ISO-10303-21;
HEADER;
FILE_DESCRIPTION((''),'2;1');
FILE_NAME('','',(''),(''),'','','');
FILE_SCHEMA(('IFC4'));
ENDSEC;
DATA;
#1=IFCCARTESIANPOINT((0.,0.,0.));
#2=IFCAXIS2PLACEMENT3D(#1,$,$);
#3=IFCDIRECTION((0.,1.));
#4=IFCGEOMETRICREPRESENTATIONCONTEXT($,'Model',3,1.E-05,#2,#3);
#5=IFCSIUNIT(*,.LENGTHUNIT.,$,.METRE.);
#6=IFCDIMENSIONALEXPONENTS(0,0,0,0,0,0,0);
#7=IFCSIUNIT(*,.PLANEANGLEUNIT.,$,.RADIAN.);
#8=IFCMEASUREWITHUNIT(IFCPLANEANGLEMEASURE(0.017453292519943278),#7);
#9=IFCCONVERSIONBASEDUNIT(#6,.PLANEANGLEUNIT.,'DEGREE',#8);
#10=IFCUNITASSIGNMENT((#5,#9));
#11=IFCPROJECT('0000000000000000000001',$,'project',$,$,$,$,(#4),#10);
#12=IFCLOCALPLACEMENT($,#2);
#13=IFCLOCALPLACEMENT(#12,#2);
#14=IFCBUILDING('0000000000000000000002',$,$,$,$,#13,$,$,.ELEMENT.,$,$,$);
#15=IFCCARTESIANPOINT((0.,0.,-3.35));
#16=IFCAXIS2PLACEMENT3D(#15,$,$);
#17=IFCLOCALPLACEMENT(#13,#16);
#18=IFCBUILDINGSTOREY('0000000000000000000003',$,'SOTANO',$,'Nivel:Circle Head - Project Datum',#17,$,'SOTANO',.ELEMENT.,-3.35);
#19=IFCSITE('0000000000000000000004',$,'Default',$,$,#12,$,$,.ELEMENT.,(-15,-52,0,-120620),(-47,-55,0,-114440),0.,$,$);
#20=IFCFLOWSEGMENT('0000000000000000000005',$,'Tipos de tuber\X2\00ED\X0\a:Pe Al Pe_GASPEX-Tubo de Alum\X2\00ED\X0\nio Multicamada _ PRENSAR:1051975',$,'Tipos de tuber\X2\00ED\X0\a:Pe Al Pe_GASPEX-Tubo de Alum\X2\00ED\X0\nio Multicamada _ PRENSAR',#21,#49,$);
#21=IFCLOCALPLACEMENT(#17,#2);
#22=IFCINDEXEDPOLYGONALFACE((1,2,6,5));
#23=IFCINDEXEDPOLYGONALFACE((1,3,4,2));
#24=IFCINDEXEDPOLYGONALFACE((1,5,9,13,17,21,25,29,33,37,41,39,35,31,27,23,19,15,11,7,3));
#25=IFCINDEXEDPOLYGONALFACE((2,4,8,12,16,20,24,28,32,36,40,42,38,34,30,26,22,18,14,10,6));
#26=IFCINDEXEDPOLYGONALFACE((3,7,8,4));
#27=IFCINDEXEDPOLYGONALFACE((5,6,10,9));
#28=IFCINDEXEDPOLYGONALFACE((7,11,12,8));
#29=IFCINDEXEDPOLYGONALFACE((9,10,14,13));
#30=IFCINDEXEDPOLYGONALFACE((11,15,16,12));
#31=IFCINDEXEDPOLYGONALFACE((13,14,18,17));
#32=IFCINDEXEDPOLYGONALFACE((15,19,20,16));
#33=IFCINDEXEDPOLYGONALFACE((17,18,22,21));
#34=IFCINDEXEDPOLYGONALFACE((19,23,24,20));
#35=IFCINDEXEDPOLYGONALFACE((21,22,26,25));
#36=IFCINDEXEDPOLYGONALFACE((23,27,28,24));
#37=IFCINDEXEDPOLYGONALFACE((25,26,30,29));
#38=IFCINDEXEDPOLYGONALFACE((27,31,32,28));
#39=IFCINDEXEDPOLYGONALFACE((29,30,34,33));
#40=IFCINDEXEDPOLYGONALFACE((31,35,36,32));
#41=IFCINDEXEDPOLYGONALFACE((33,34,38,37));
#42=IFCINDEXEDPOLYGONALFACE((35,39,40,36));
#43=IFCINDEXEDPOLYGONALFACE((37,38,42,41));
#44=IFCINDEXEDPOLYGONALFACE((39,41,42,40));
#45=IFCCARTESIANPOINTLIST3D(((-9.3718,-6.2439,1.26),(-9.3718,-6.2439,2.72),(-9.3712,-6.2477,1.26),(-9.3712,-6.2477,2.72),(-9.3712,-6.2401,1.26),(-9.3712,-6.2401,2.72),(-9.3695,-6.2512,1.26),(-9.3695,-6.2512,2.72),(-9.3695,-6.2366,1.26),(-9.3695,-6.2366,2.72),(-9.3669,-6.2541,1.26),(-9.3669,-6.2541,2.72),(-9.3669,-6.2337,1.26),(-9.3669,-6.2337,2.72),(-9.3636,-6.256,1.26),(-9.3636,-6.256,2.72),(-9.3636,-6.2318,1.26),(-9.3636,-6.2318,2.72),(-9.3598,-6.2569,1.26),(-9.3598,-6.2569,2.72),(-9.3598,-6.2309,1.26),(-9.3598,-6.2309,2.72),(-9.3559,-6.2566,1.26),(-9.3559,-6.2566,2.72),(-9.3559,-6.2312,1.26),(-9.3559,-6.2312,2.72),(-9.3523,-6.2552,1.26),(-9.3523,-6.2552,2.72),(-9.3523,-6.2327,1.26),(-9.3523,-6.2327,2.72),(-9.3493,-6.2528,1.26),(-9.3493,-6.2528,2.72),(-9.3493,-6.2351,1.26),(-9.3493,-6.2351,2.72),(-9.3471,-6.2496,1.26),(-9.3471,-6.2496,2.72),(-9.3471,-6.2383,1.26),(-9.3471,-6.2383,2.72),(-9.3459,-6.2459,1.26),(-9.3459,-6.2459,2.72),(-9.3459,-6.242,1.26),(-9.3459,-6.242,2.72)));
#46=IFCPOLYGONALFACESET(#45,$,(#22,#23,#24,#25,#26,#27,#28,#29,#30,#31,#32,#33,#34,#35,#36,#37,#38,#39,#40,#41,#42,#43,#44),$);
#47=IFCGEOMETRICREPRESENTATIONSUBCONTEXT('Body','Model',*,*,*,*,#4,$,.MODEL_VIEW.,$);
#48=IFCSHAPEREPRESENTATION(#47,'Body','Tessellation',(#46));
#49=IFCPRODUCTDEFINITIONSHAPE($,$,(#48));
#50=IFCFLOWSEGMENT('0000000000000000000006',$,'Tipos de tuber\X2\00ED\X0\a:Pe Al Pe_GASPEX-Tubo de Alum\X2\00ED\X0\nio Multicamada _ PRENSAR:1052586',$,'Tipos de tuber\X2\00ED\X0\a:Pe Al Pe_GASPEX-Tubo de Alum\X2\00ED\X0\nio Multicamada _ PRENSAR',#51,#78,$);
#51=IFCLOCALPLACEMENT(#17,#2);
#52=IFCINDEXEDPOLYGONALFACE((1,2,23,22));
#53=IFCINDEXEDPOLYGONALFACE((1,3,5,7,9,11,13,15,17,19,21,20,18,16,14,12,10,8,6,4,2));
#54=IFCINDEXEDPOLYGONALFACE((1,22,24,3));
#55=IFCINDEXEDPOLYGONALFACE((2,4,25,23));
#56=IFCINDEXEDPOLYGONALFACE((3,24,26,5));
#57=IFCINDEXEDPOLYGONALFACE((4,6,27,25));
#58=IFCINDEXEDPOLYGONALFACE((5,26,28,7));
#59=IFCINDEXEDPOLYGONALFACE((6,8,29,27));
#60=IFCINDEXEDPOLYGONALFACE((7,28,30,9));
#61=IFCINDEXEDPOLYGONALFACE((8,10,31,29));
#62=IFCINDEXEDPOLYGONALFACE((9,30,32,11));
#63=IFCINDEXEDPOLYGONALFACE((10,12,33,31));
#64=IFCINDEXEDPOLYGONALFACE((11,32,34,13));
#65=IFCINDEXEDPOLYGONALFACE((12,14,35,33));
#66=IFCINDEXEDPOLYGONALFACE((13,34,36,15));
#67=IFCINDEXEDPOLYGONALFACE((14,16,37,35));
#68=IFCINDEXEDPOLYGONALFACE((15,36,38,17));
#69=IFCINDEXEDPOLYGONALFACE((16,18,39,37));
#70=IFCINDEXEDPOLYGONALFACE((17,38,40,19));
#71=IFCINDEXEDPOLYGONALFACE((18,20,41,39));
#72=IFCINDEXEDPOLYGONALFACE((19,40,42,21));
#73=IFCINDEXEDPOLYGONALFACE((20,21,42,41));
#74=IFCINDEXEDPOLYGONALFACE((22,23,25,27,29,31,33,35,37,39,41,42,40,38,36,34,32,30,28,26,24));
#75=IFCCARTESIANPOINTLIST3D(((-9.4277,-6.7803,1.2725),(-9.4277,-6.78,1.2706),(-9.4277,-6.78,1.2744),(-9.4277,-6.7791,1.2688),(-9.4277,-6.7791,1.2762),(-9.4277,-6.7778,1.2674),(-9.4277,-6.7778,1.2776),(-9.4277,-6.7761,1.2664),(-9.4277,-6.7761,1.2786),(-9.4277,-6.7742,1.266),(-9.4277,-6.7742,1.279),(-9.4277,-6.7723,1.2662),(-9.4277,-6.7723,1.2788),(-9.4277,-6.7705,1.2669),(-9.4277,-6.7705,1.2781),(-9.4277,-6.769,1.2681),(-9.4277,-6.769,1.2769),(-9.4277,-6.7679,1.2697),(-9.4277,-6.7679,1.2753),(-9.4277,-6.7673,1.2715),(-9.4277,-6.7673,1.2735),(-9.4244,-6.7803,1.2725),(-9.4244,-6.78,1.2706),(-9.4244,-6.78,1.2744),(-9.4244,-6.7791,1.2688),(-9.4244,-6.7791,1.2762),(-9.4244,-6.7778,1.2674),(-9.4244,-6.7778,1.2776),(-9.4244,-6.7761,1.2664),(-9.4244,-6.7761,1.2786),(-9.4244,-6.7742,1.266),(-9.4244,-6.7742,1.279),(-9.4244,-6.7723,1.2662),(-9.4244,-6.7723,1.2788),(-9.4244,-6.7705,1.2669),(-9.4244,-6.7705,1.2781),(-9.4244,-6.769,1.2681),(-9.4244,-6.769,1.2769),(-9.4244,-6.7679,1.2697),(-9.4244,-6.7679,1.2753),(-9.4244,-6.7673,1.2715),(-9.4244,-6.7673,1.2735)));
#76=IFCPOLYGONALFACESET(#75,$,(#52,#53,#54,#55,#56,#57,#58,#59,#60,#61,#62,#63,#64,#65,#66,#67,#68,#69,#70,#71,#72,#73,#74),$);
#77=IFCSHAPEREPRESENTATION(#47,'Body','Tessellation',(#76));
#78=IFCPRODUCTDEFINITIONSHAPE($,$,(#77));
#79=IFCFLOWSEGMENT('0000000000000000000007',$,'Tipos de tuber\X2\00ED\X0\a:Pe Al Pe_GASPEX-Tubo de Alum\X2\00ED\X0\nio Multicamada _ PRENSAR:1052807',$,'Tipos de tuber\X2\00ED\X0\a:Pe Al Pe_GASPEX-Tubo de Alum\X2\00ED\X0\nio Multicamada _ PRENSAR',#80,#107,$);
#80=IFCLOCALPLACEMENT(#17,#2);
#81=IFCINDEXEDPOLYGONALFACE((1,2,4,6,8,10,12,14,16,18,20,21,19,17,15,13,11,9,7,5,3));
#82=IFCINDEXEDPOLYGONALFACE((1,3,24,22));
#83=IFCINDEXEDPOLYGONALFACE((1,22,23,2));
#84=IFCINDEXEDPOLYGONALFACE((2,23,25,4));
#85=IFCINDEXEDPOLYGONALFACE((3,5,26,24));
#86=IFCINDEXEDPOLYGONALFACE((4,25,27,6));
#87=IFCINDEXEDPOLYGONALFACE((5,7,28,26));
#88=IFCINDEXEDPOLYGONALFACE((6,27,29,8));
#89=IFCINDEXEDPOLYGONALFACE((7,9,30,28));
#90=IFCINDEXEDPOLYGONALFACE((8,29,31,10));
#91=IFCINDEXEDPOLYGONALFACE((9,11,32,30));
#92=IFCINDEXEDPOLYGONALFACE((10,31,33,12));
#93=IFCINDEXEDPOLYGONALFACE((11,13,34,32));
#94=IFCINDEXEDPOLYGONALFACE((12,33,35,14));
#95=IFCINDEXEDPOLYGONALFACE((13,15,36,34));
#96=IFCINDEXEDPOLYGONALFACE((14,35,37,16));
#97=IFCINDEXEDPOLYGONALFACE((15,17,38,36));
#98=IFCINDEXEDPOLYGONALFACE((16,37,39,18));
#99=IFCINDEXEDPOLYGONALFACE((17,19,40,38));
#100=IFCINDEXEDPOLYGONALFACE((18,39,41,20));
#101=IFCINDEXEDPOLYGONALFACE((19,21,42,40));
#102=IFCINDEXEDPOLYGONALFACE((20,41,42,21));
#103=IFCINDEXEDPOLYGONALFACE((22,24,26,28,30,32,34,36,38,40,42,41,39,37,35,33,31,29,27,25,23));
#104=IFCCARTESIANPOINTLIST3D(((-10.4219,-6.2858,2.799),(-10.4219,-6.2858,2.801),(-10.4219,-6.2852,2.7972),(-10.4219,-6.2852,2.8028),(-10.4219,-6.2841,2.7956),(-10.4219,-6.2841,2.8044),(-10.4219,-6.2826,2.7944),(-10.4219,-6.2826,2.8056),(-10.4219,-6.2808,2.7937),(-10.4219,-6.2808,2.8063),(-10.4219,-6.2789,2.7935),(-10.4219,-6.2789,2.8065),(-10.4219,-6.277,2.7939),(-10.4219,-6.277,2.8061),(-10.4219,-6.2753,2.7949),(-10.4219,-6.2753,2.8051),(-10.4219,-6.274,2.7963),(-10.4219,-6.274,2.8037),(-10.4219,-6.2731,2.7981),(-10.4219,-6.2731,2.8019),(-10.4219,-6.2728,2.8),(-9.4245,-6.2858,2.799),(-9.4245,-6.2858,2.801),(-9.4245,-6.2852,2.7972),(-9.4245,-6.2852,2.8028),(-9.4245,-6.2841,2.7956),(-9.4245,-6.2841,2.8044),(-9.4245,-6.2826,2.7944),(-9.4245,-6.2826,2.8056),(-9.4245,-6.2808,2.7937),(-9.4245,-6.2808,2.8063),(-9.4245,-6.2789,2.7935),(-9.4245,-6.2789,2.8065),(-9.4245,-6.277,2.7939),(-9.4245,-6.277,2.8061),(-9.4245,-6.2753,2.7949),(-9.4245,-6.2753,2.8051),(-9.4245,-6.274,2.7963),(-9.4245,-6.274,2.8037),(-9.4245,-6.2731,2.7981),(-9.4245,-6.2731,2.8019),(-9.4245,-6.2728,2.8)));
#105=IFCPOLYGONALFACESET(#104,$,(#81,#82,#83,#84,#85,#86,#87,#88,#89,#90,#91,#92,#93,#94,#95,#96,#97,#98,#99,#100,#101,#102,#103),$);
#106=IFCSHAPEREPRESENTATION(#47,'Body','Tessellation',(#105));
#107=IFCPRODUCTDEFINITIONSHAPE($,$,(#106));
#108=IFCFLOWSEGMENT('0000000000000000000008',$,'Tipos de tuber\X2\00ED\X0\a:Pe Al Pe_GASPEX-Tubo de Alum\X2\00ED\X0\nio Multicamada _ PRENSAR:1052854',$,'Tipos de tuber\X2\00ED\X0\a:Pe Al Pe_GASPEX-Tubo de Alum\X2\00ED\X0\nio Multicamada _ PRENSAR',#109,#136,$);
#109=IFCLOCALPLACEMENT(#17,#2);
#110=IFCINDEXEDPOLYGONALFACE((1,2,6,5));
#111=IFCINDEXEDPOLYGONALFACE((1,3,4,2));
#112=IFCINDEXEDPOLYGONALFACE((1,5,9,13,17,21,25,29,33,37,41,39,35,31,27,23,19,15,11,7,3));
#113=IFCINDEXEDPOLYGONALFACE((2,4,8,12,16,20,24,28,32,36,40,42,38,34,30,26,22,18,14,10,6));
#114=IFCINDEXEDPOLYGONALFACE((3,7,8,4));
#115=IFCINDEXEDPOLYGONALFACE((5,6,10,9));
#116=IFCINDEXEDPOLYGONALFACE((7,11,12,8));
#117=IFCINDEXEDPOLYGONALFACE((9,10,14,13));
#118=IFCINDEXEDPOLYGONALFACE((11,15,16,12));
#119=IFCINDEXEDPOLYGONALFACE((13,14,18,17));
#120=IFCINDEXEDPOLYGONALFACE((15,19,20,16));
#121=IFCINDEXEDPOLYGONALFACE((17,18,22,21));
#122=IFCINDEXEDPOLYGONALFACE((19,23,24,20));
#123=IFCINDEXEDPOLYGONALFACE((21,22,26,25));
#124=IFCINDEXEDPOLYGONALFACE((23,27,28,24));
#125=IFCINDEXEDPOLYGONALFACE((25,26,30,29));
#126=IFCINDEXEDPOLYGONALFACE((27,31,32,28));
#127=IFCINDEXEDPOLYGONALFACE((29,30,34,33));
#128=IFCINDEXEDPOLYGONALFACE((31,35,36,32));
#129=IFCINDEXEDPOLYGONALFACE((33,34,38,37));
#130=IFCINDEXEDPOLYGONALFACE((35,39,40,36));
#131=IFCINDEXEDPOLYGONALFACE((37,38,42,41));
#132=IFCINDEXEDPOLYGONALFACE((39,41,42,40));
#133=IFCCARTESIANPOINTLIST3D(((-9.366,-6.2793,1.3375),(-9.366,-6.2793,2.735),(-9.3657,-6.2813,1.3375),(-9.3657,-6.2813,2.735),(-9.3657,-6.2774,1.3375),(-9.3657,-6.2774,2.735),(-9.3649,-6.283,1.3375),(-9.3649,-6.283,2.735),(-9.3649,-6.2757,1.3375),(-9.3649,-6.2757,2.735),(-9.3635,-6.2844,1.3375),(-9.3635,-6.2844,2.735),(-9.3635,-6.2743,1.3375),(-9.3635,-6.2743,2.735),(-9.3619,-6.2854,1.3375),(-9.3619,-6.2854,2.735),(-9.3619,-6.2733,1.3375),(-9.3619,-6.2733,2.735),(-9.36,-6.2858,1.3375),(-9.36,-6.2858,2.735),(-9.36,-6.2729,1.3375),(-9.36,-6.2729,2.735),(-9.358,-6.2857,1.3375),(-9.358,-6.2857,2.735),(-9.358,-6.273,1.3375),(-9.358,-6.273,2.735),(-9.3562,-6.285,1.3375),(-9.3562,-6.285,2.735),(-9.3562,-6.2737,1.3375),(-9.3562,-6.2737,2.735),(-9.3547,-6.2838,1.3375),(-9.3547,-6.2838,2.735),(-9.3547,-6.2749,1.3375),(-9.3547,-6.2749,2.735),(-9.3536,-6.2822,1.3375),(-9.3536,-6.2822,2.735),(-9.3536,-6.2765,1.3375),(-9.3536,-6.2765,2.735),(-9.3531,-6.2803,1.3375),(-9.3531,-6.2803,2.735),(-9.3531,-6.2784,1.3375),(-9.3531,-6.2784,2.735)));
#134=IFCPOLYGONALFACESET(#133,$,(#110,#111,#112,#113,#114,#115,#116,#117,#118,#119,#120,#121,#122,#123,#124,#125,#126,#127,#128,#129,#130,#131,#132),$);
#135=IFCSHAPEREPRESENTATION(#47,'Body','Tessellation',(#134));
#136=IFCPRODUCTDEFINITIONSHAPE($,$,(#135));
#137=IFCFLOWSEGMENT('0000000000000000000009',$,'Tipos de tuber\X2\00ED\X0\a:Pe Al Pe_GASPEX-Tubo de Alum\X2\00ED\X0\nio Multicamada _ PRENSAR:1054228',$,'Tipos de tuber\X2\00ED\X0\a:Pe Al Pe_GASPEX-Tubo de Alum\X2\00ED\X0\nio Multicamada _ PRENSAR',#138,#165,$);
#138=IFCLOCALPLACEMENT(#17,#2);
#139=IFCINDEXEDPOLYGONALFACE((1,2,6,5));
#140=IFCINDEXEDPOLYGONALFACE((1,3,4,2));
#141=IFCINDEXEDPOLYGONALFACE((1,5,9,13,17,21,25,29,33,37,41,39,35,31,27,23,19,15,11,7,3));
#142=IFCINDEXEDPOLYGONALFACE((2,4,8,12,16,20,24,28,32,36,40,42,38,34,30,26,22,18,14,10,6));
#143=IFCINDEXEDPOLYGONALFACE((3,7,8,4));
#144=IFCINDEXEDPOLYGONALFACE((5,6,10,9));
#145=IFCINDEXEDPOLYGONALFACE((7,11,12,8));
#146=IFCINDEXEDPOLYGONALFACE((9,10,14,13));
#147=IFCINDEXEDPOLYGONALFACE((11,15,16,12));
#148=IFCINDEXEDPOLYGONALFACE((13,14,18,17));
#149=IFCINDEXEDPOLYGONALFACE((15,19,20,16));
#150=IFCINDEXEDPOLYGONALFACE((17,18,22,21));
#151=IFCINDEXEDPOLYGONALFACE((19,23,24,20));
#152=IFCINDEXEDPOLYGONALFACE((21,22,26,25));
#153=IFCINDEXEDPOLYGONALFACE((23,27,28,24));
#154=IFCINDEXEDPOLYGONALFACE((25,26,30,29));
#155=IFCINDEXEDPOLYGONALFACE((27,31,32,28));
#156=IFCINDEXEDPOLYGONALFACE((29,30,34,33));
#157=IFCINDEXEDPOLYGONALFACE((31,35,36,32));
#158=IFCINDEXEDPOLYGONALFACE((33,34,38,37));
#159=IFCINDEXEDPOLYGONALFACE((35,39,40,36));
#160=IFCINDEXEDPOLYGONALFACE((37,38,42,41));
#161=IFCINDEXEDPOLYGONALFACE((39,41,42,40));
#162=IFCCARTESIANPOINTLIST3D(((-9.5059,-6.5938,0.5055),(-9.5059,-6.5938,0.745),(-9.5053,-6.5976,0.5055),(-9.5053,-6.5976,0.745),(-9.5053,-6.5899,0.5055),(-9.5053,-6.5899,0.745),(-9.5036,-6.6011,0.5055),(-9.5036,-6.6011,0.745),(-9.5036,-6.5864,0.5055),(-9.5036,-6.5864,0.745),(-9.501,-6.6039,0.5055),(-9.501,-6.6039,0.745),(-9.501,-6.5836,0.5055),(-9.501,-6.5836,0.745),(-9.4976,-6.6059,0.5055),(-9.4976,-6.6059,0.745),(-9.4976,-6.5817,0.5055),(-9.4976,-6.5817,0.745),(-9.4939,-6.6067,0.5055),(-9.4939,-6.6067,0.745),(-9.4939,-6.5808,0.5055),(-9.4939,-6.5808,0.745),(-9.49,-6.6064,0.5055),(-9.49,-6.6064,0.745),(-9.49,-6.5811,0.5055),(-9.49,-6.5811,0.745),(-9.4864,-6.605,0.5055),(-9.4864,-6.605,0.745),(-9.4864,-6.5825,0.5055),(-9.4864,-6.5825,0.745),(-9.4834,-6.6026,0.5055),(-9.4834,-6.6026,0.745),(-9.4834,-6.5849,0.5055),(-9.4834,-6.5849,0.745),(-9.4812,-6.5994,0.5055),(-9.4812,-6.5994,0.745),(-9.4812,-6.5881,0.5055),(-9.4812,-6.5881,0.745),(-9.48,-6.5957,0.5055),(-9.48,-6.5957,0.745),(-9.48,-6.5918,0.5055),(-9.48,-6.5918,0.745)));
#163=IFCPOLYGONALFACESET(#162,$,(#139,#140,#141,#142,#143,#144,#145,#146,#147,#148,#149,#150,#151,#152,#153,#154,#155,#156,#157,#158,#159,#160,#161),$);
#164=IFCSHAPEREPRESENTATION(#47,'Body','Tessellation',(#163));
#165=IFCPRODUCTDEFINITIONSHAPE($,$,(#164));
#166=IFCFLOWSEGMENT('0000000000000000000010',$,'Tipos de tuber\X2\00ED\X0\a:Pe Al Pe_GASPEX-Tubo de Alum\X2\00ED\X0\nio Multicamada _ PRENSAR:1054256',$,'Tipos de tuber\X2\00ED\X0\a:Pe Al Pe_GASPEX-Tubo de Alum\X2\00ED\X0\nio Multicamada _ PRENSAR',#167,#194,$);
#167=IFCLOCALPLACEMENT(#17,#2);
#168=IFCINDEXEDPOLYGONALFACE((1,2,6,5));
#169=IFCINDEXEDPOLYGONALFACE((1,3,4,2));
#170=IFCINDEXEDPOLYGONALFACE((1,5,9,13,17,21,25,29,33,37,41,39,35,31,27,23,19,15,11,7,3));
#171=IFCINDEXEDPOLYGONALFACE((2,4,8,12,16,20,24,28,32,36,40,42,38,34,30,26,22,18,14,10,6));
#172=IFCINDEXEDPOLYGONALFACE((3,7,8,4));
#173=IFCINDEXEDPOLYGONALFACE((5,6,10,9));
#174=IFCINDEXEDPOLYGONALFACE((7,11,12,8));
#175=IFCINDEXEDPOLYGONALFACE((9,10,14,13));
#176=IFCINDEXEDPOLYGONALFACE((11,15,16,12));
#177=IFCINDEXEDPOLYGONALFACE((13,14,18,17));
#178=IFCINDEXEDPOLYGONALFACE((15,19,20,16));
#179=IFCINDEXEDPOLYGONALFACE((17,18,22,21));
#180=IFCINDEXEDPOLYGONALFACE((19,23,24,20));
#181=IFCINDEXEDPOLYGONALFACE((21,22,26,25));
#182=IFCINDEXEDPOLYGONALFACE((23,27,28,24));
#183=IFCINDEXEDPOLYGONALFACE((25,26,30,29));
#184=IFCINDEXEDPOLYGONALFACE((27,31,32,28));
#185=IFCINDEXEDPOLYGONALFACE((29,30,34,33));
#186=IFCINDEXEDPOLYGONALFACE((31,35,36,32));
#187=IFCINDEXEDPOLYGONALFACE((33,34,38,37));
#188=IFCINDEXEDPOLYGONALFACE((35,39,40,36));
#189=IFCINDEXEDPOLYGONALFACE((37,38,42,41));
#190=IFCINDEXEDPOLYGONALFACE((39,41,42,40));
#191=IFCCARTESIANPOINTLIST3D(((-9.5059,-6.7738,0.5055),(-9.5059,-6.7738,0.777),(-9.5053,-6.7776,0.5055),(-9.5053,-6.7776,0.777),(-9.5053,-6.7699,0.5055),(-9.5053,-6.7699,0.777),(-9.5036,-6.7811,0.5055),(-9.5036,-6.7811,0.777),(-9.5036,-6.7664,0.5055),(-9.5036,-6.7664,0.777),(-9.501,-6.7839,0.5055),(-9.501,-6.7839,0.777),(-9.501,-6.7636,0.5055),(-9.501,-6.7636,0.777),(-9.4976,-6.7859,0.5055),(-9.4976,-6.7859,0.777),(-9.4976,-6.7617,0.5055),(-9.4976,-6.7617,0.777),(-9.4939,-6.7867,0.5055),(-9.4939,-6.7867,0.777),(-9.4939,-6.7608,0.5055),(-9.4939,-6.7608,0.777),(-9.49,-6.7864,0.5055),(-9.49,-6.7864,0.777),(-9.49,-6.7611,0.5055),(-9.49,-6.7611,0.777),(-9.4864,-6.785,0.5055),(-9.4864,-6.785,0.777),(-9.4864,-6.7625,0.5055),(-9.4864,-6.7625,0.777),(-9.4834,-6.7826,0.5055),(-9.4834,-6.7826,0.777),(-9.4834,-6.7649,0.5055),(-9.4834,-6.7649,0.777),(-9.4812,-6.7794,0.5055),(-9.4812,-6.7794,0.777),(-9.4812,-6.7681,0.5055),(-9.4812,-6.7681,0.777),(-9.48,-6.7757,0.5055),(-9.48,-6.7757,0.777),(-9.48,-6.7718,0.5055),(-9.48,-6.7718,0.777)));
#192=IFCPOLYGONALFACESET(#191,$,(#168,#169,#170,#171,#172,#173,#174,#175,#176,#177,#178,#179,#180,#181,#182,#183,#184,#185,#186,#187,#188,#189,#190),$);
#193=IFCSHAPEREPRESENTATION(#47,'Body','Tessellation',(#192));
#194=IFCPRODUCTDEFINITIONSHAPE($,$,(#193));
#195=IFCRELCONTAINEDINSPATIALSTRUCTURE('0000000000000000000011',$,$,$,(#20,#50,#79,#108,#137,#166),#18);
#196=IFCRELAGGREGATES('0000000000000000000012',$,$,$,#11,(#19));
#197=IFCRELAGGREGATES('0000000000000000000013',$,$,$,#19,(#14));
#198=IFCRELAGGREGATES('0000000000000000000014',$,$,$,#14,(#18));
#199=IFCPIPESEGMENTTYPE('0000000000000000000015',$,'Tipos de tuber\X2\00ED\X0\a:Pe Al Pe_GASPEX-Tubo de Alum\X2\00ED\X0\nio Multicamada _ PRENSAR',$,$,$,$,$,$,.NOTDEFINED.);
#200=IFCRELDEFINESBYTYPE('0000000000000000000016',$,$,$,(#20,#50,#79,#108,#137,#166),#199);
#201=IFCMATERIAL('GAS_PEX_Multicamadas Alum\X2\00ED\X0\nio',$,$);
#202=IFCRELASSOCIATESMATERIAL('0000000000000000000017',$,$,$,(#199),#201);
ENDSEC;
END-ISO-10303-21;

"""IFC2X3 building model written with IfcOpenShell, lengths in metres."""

from ifc_helpers import new_model, entity, si_unit, converted_unit, direction, frame, frame_2d, origin, origin_2d_with_axis, place, context, subcontext, project, spatial, circle, extrude, material, type_object, element, save


model = new_model("IFC2X3")

# Units and contexts
model_context = context("Model", 3, precision=1e-05, world=origin(), true_north=direction((0.0, 1.0)))
body_context = subcontext(model_context, "Body", "Model", "MODEL_VIEW")
ifc_project = project(units=[si_unit("LENGTHUNIT", "METRE"), converted_unit("PLANEANGLEUNIT", "DEGREE", entity("IfcPlaneAngleMeasure", 0.017453292519943278), si_unit("PLANEANGLEUNIT", "RADIAN"), dimensions=[0, 0, 0, 0, 0, 0, 0])], contexts=[model_context])

# Site, building, storey
site_placement = place(None, origin())
site = spatial("IfcSite", under=ifc_project, at=site_placement, Name="Default", CompositionType="ELEMENT", RefLatitude=(-15, -52, 0, -120620), RefLongitude=(-47, -55, 0, -114440), RefElevation=0.0)
building_placement = place(site_placement, origin())
building = spatial("IfcBuilding", under=site, at=building_placement, CompositionType="ELEMENT")
storey_placement = place(building_placement, frame((0.0, 0.0, -3.35)))
storey = spatial("IfcBuildingStorey", under=building, at=storey_placement, Name="SOTANO", ObjectType="Nivel:Circle Head - Project Datum", LongName="SOTANO", CompositionType="ELEMENT", Elevation=-3.35)

# Flow segments
ifc_material = material(Name="GAS_PEX_Multicamadas Alumínio")
pipe_segment_type_1 = type_object("IfcPipeSegmentType", Name="Tipos de tubería:Pe Al Pe_GASPEX-Tubo de Alumínio Multicamada _ PRENSAR", PredefinedType="NOTDEFINED", material=ifc_material)
flow_segment_1_placement = place(storey_placement, origin())
element("IfcFlowSegment", 1, at=flow_segment_1_placement, inside=storey, type_object=pipe_segment_type_1, Name="Tipos de tubería:Pe Al Pe_GASPEX-Tubo de Alumínio Multicamada _ PRENSAR:1051975", ObjectType="Tipos de tubería:Pe Al Pe_GASPEX-Tubo de Alumínio Multicamada _ PRENSAR", context=body_context, shape_type="SweptSolid", body=[
    extrude(circle(Radius=0.013, at=origin_2d_with_axis()), frame((-9.3588, -6.2439, 1.26), z_axis=(0.0, 0.0, 1.0), x_axis=(-1.0, 0.0, 0.0)), (0.0, 0.0, 1.0), 1.46),
])
flow_segment_2_placement = place(storey_placement, origin())
element("IfcFlowSegment", 2, at=flow_segment_2_placement, inside=storey, type_object=pipe_segment_type_1, Name="Tipos de tubería:Pe Al Pe_GASPEX-Tubo de Alumínio Multicamada _ PRENSAR:1052586", ObjectType="Tipos de tubería:Pe Al Pe_GASPEX-Tubo de Alumínio Multicamada _ PRENSAR", context=body_context, shape_type="SweptSolid", body=[
    extrude(circle(Radius=0.0065, at=origin_2d_with_axis()), frame((-9.4277, -6.7738, 1.2725), z_axis=(1.0, 0.0, 0.0), x_axis=(0.0, -1.0, 0.0)), (0.0, 0.0, 1.0), 0.0033),
])
flow_segment_3_placement = place(storey_placement, origin())
element("IfcFlowSegment", 3, at=flow_segment_3_placement, inside=storey, type_object=pipe_segment_type_1, Name="Tipos de tubería:Pe Al Pe_GASPEX-Tubo de Alumínio Multicamada _ PRENSAR:1052807", ObjectType="Tipos de tubería:Pe Al Pe_GASPEX-Tubo de Alumínio Multicamada _ PRENSAR", context=body_context, shape_type="SweptSolid", body=[
    extrude(circle(Radius=0.0065, at=origin_2d_with_axis()), frame((-10.4219, -6.2793, 2.8), z_axis=(1.0, 0.0, 0.0), x_axis=(0.0, 1.0, 0.0)), (0.0, 0.0, 1.0), 0.9974),
])
flow_segment_4_placement = place(storey_placement, origin())
element("IfcFlowSegment", 4, at=flow_segment_4_placement, inside=storey, type_object=pipe_segment_type_1, Name="Tipos de tubería:Pe Al Pe_GASPEX-Tubo de Alumínio Multicamada _ PRENSAR:1052854", ObjectType="Tipos de tubería:Pe Al Pe_GASPEX-Tubo de Alumínio Multicamada _ PRENSAR", context=body_context, shape_type="SweptSolid", body=[
    extrude(circle(Radius=0.0065, at=origin_2d_with_axis()), frame((-9.3595, -6.2793, 1.3375), z_axis=(0.0, 0.0, 1.0), x_axis=(-1.0, 0.0, 0.0)), (0.0, 0.0, 1.0), 1.3975),
])
flow_segment_5_placement = place(storey_placement, origin())
element("IfcFlowSegment", 5, at=flow_segment_5_placement, inside=storey, type_object=pipe_segment_type_1, Name="Tipos de tubería:Pe Al Pe_GASPEX-Tubo de Alumínio Multicamada _ PRENSAR:1054228", ObjectType="Tipos de tubería:Pe Al Pe_GASPEX-Tubo de Alumínio Multicamada _ PRENSAR", context=body_context, shape_type="SweptSolid", body=[
    extrude(circle(Radius=0.013, at=origin_2d_with_axis()), frame((-9.4929, -6.5938, 0.5055), z_axis=(0.0, 0.0, 1.0), x_axis=(-1.0, 0.0, 0.0)), (0.0, 0.0, 1.0), 0.2395),
])
flow_segment_6_placement = place(storey_placement, origin())
element("IfcFlowSegment", 6, at=flow_segment_6_placement, inside=storey, type_object=pipe_segment_type_1, Name="Tipos de tubería:Pe Al Pe_GASPEX-Tubo de Alumínio Multicamada _ PRENSAR:1054256", ObjectType="Tipos de tubería:Pe Al Pe_GASPEX-Tubo de Alumínio Multicamada _ PRENSAR", context=body_context, shape_type="SweptSolid", body=[
    extrude(circle(Radius=0.013, at=frame_2d((0.0, 0.0), x_axis=(1.0, 0.0))), frame((-9.4929, -6.7738, 0.5055), z_axis=(0.0, 0.0, 1.0), x_axis=(-1.0, 0.0, 0.0)), (0.0, 0.0, 1.0), 0.2714),
])

save(model, "model.ifc")
